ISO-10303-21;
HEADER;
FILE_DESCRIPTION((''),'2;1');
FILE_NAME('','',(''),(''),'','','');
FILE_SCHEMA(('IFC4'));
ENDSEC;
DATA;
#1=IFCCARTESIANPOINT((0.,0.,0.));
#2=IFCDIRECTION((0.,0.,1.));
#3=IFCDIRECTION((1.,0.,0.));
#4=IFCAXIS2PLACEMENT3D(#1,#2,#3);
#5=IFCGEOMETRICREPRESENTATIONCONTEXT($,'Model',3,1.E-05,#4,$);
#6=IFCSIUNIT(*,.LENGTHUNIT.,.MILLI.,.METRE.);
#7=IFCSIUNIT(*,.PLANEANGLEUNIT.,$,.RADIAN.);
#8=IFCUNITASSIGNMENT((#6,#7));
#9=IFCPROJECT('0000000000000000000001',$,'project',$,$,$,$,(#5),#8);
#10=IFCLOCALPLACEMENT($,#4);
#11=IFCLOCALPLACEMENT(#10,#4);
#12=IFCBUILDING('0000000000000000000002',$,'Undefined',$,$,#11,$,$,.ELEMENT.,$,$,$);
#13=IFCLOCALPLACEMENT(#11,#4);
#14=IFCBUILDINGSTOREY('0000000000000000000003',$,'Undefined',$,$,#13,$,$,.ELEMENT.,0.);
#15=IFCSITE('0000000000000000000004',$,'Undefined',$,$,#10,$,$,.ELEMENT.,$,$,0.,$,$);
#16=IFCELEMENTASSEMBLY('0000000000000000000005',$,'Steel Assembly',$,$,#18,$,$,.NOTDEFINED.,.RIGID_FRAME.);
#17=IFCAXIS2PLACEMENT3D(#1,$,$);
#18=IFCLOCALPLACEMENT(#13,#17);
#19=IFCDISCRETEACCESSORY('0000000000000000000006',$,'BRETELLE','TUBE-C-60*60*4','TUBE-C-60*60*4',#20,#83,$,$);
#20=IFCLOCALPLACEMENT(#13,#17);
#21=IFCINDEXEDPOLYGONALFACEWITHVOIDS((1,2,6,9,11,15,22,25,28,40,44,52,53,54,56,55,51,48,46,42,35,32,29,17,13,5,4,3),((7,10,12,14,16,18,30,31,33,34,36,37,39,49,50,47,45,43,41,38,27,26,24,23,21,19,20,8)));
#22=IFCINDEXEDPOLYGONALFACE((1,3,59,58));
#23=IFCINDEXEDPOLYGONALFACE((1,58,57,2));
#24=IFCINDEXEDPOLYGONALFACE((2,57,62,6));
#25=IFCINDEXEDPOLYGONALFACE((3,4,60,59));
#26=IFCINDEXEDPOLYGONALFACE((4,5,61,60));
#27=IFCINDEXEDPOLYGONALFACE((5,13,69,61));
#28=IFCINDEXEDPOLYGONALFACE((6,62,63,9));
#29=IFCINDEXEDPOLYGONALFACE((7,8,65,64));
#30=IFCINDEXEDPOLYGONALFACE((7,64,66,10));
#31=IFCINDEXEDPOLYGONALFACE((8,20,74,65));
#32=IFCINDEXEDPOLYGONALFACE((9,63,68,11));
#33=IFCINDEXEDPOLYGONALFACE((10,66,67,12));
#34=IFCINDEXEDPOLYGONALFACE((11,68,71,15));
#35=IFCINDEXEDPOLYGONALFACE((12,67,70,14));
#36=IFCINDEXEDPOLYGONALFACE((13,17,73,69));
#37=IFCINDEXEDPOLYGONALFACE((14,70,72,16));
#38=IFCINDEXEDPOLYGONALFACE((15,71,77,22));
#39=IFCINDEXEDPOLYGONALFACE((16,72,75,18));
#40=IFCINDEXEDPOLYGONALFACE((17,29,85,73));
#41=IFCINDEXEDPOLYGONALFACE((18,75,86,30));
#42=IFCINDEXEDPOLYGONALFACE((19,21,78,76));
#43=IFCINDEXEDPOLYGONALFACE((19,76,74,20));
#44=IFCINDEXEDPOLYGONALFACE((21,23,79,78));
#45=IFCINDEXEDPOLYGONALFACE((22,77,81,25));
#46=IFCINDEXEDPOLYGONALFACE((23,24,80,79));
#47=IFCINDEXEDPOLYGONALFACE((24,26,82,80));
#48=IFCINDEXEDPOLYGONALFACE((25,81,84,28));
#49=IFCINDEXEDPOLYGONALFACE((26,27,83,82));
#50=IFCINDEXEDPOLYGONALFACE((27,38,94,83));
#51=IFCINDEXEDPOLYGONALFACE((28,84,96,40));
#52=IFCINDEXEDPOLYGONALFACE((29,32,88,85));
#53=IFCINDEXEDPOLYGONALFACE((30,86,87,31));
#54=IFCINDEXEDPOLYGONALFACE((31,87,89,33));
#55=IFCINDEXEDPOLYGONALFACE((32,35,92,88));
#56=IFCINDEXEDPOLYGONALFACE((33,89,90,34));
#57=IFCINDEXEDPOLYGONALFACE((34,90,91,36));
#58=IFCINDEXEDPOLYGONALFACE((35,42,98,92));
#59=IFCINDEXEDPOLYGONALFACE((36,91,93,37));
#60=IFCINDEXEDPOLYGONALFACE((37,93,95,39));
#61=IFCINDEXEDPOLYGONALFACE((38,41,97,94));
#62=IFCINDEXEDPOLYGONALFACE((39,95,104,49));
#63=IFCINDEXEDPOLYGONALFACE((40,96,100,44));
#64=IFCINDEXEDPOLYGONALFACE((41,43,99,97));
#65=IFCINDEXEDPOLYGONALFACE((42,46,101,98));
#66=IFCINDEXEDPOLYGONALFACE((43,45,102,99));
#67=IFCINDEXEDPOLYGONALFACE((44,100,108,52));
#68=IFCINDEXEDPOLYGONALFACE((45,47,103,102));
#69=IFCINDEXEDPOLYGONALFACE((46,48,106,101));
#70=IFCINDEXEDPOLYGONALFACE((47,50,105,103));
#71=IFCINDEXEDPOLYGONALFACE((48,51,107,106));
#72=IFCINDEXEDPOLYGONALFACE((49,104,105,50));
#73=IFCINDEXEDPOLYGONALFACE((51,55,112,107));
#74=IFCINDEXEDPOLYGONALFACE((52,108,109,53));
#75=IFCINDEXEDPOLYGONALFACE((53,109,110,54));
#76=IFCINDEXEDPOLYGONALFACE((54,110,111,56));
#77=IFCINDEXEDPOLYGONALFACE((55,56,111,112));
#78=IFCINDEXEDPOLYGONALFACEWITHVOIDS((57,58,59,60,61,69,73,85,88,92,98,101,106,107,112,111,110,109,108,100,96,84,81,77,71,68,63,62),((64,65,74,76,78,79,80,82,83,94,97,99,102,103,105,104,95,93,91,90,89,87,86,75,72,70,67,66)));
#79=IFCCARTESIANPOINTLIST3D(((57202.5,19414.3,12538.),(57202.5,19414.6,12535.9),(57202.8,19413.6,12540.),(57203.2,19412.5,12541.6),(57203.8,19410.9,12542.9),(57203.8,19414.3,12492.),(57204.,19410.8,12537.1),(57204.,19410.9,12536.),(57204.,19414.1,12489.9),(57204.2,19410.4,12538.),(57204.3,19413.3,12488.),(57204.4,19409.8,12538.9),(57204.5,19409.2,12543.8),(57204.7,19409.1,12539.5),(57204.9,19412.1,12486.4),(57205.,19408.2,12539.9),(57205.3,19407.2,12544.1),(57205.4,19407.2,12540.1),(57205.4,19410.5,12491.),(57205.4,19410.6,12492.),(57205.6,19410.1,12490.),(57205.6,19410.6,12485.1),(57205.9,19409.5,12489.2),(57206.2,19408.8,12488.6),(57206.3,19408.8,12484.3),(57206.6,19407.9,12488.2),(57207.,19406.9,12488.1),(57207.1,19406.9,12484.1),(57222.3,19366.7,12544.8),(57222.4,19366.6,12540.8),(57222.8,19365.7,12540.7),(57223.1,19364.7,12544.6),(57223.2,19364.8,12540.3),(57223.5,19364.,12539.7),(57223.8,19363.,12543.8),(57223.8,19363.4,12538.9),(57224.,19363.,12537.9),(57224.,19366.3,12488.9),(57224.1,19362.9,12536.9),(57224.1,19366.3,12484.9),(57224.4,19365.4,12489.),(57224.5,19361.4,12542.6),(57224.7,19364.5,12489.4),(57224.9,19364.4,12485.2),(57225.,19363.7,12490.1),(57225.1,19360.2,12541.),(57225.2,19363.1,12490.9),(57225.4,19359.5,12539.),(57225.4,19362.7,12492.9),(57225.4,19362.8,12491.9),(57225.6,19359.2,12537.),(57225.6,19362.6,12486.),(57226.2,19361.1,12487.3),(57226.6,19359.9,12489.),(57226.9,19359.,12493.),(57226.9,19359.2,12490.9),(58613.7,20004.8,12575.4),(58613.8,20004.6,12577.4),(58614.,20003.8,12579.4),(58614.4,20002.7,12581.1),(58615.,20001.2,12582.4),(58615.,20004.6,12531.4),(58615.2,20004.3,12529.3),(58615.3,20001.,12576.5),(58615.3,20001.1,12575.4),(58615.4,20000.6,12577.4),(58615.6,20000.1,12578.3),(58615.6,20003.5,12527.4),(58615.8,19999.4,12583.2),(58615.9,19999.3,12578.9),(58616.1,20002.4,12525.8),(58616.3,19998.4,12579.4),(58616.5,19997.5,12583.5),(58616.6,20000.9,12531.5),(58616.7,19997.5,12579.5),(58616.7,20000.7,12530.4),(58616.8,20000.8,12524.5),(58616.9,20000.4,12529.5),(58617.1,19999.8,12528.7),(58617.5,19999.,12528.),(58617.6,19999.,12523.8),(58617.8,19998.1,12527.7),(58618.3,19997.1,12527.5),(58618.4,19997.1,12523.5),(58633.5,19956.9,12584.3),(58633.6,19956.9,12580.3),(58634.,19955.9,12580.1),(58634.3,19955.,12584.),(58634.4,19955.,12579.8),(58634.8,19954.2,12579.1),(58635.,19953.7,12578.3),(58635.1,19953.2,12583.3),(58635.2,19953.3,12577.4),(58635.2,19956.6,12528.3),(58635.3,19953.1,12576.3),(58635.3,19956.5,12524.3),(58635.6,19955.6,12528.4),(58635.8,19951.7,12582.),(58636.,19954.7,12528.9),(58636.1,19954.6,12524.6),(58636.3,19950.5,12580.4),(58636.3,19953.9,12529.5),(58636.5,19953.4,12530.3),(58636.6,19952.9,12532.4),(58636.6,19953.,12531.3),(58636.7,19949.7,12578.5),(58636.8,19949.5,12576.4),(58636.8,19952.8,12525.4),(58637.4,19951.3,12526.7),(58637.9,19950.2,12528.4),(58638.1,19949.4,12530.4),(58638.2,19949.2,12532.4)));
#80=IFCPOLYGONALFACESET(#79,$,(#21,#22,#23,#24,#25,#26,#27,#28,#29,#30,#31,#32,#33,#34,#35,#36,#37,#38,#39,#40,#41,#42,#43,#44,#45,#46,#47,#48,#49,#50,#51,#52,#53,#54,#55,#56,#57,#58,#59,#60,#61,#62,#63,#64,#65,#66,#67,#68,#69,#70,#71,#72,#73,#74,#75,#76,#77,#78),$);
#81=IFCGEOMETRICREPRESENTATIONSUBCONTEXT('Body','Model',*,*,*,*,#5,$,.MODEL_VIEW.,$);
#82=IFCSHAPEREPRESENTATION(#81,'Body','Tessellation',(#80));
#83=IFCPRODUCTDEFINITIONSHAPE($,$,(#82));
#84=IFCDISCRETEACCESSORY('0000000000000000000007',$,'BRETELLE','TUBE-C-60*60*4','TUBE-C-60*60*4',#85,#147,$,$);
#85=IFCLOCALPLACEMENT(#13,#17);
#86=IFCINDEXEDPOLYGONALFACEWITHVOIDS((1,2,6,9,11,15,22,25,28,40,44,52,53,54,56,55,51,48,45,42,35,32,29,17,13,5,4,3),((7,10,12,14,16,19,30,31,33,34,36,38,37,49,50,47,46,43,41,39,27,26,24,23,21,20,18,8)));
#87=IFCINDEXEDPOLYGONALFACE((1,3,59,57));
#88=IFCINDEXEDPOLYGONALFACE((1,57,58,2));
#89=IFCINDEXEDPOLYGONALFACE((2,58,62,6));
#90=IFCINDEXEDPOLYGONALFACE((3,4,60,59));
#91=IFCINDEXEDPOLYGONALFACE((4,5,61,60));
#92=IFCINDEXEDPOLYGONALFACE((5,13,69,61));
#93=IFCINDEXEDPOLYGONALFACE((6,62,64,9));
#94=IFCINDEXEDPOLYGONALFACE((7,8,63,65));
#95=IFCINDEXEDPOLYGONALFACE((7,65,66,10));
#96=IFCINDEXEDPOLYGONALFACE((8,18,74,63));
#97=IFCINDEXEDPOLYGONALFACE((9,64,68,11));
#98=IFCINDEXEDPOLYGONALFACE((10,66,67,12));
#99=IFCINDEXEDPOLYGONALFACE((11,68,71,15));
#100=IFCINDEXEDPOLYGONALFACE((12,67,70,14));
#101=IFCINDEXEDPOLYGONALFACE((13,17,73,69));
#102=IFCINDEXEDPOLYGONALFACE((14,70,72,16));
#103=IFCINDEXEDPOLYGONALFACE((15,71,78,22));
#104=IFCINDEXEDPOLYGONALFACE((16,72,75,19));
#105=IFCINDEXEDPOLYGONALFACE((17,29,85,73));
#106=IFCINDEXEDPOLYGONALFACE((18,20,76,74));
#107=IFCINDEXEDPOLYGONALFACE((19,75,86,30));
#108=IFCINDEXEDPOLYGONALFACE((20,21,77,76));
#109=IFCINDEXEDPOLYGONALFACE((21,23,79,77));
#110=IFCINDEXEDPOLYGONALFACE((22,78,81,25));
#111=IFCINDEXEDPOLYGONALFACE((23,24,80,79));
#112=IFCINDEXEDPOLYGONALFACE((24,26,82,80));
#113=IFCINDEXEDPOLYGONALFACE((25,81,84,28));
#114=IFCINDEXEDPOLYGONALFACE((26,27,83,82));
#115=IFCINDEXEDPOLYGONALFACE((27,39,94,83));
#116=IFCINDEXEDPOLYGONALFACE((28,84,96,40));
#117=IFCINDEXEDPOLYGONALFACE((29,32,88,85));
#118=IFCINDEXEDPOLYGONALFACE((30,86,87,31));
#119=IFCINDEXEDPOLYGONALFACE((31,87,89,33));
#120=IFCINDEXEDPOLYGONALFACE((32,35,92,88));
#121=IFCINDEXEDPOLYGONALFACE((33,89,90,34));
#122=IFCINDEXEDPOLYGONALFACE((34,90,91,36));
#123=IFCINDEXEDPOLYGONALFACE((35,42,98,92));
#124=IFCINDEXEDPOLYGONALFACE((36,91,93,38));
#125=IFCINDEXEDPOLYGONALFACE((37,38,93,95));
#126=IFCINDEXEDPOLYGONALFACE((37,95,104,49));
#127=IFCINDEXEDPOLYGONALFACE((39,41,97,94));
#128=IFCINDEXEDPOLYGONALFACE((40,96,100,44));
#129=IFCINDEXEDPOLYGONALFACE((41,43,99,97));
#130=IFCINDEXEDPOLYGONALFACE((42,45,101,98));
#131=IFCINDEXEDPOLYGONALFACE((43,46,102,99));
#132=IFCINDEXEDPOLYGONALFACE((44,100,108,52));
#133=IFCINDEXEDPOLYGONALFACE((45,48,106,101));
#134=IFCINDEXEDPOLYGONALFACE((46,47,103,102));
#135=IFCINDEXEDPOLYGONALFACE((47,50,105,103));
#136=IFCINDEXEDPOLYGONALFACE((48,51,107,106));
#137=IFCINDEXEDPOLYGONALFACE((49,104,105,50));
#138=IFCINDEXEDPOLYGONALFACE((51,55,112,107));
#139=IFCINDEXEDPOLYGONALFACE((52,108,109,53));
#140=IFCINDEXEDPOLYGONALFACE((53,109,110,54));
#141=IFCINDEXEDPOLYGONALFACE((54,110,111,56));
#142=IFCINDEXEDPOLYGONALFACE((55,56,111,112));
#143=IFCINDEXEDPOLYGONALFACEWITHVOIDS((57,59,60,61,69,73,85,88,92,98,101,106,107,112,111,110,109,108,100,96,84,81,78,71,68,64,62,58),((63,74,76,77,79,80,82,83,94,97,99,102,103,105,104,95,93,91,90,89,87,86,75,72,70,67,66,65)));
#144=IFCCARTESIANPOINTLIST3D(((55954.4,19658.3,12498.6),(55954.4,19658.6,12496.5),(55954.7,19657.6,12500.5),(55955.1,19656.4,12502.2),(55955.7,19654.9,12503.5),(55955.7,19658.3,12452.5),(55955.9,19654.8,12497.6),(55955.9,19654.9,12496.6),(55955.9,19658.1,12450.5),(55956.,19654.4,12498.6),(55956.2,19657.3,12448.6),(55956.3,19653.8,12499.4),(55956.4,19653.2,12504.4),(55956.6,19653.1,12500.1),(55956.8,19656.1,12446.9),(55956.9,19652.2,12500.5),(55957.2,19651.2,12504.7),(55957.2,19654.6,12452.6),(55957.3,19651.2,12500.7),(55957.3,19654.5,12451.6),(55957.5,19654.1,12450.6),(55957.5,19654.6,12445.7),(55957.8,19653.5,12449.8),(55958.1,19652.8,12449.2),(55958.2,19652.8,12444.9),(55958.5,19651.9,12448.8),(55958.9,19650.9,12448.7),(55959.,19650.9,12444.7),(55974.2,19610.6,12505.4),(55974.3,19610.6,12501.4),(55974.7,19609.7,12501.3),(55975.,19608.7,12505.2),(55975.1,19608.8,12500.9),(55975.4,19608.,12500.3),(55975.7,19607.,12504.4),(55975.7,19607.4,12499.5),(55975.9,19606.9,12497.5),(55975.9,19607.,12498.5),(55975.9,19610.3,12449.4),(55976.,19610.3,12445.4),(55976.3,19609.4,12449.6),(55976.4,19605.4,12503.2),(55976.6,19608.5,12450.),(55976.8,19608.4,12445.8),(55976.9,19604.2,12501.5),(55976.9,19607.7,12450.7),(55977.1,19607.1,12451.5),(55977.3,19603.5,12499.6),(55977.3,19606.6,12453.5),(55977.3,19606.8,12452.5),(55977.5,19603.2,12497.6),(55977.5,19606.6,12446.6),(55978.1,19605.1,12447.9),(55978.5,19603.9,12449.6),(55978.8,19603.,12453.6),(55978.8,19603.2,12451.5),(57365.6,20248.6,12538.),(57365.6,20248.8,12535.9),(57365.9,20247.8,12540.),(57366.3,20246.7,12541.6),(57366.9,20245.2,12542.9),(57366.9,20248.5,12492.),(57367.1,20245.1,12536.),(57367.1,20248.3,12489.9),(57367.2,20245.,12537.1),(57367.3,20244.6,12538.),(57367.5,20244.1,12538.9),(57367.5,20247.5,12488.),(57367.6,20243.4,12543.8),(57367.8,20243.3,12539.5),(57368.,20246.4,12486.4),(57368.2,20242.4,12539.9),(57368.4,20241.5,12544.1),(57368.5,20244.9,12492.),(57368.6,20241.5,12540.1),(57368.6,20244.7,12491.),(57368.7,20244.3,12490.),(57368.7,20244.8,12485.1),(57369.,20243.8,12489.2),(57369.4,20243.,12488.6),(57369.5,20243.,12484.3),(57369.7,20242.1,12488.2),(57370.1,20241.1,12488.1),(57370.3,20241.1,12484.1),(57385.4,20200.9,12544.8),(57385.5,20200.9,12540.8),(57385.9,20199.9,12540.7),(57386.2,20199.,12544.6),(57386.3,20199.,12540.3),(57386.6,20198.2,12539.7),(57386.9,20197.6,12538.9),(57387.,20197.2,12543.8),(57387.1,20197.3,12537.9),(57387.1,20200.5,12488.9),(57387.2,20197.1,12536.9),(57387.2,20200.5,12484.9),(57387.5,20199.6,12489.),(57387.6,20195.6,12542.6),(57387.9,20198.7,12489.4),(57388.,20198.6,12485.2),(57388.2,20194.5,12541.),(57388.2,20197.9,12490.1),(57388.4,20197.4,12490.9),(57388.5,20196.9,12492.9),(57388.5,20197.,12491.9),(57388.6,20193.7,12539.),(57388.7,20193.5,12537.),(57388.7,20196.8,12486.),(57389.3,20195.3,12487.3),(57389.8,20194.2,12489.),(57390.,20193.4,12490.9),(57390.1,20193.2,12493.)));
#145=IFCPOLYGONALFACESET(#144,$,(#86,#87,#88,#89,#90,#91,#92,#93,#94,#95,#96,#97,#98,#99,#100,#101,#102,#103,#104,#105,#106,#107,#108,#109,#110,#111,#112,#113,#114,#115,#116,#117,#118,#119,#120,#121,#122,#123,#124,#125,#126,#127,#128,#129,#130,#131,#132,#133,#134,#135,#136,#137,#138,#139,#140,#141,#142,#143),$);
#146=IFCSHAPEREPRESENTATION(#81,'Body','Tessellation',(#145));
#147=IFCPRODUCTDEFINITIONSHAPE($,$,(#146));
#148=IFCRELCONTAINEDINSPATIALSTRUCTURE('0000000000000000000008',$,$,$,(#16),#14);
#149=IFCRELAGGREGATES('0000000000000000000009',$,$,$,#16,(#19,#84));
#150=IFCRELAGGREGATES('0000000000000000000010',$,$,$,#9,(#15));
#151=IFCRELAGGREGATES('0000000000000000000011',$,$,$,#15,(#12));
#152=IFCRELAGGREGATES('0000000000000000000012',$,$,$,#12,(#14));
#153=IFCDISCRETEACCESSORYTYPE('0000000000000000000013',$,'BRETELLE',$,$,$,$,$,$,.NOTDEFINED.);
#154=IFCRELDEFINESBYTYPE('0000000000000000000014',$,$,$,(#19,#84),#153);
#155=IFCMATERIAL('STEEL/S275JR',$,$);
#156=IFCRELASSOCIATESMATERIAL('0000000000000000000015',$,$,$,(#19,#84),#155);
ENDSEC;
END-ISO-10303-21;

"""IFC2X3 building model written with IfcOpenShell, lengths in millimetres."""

from ifc_helpers import new_model, si_unit, frame, origin_with_axes, origin_2d_with_axis, place, context, subcontext, project, spatial, hollow_rectangle, extrude, material, type_object, element, aggregate, save


model = new_model("IFC2X3")

# Units and contexts
model_context = context("Model", 3, precision=1e-05, world=origin_with_axes())
body_context = subcontext(model_context, "Body", "Model", "MODEL_VIEW")
ifc_project = project(units=[si_unit("LENGTHUNIT", "METRE", prefix="MILLI"), si_unit("PLANEANGLEUNIT", "RADIAN")], contexts=[model_context])

# Site, building, storey
site_placement = place(None, origin_with_axes())
site = spatial("IfcSite", under=ifc_project, at=site_placement, Name="Undefined", CompositionType="ELEMENT", RefElevation=0.0)
building_placement = place(site_placement, origin_with_axes())
building = spatial("IfcBuilding", under=site, at=building_placement, Name="Undefined", CompositionType="ELEMENT")
storey_placement = place(building_placement, origin_with_axes())
storey = spatial("IfcBuildingStorey", under=building, at=storey_placement, Name="Undefined", CompositionType="ELEMENT", Elevation=0.0)

# Shared definitions
ifc_material_1 = material(Name="STEEL/S275JR")

# Element assembly, discrete accessories
assembly_1_placement = place(storey_placement, origin_with_axes())
assembly_1 = element("IfcElementAssembly", 1, at=assembly_1_placement, inside=storey, Name="Steel Assembly", AssemblyPlace="NOTDEFINED", PredefinedType="RIGID_FRAME")
discrete_accessory_type_1 = type_object("IfcDiscreteAccessoryType", Name="BRETELLE")
discrete_accessory_1_placement = place(assembly_1_placement, frame((58625.9, 19977.0, 12553.9), z_axis=(-0.385384, 0.922596, -0.017211), x_axis=(-0.922255, -0.385722, -0.025763)))
discrete_accessory_1 = element("IfcDiscreteAccessory", 2, at=discrete_accessory_1_placement, type_object=discrete_accessory_type_1, material=ifc_material_1, Name="BRETELLE", Description="TUBE-C-60*60*4", ObjectType="TUBE-C-60*60*4", context=body_context, shape_type="SweptSolid", body=[
    extrude(hollow_rectangle(XDim=60.0, YDim=60.0, WallThickness=4.0, InnerFilletRadius=4.0, OuterFilletRadius=8.0, at=origin_2d_with_axis()), frame((1530.2, 0.0, 0.0), z_axis=(-1.0, 0.0, 0.0), x_axis=(0.0, -1.0, 0.0)), (0.0, 0.0, 1.0), 1530.2),
])
discrete_accessory_2_placement = place(assembly_1_placement, frame((57377.8, 20221.0, 12514.5), z_axis=(-0.385384, 0.922596, -0.017211), x_axis=(-0.922255, -0.385722, -0.025763)))
discrete_accessory_2 = element("IfcDiscreteAccessory", 3, at=discrete_accessory_2_placement, type_object=discrete_accessory_type_1, material=ifc_material_1, Name="BRETELLE", Description="TUBE-C-60*60*4", ObjectType="TUBE-C-60*60*4", context=body_context, shape_type="SweptSolid", body=[
    extrude(hollow_rectangle(XDim=60.0, YDim=60.0, WallThickness=4.0, InnerFilletRadius=4.0, OuterFilletRadius=8.0, at=origin_2d_with_axis()), frame((1530.2, 0.0, 0.0), z_axis=(-1.0, 0.0, 0.0), x_axis=(0.0, -1.0, 0.0)), (0.0, 0.0, 1.0), 1530.2),
])
aggregate(assembly_1, [discrete_accessory_1, discrete_accessory_2])

save(model, "model.ifc")
